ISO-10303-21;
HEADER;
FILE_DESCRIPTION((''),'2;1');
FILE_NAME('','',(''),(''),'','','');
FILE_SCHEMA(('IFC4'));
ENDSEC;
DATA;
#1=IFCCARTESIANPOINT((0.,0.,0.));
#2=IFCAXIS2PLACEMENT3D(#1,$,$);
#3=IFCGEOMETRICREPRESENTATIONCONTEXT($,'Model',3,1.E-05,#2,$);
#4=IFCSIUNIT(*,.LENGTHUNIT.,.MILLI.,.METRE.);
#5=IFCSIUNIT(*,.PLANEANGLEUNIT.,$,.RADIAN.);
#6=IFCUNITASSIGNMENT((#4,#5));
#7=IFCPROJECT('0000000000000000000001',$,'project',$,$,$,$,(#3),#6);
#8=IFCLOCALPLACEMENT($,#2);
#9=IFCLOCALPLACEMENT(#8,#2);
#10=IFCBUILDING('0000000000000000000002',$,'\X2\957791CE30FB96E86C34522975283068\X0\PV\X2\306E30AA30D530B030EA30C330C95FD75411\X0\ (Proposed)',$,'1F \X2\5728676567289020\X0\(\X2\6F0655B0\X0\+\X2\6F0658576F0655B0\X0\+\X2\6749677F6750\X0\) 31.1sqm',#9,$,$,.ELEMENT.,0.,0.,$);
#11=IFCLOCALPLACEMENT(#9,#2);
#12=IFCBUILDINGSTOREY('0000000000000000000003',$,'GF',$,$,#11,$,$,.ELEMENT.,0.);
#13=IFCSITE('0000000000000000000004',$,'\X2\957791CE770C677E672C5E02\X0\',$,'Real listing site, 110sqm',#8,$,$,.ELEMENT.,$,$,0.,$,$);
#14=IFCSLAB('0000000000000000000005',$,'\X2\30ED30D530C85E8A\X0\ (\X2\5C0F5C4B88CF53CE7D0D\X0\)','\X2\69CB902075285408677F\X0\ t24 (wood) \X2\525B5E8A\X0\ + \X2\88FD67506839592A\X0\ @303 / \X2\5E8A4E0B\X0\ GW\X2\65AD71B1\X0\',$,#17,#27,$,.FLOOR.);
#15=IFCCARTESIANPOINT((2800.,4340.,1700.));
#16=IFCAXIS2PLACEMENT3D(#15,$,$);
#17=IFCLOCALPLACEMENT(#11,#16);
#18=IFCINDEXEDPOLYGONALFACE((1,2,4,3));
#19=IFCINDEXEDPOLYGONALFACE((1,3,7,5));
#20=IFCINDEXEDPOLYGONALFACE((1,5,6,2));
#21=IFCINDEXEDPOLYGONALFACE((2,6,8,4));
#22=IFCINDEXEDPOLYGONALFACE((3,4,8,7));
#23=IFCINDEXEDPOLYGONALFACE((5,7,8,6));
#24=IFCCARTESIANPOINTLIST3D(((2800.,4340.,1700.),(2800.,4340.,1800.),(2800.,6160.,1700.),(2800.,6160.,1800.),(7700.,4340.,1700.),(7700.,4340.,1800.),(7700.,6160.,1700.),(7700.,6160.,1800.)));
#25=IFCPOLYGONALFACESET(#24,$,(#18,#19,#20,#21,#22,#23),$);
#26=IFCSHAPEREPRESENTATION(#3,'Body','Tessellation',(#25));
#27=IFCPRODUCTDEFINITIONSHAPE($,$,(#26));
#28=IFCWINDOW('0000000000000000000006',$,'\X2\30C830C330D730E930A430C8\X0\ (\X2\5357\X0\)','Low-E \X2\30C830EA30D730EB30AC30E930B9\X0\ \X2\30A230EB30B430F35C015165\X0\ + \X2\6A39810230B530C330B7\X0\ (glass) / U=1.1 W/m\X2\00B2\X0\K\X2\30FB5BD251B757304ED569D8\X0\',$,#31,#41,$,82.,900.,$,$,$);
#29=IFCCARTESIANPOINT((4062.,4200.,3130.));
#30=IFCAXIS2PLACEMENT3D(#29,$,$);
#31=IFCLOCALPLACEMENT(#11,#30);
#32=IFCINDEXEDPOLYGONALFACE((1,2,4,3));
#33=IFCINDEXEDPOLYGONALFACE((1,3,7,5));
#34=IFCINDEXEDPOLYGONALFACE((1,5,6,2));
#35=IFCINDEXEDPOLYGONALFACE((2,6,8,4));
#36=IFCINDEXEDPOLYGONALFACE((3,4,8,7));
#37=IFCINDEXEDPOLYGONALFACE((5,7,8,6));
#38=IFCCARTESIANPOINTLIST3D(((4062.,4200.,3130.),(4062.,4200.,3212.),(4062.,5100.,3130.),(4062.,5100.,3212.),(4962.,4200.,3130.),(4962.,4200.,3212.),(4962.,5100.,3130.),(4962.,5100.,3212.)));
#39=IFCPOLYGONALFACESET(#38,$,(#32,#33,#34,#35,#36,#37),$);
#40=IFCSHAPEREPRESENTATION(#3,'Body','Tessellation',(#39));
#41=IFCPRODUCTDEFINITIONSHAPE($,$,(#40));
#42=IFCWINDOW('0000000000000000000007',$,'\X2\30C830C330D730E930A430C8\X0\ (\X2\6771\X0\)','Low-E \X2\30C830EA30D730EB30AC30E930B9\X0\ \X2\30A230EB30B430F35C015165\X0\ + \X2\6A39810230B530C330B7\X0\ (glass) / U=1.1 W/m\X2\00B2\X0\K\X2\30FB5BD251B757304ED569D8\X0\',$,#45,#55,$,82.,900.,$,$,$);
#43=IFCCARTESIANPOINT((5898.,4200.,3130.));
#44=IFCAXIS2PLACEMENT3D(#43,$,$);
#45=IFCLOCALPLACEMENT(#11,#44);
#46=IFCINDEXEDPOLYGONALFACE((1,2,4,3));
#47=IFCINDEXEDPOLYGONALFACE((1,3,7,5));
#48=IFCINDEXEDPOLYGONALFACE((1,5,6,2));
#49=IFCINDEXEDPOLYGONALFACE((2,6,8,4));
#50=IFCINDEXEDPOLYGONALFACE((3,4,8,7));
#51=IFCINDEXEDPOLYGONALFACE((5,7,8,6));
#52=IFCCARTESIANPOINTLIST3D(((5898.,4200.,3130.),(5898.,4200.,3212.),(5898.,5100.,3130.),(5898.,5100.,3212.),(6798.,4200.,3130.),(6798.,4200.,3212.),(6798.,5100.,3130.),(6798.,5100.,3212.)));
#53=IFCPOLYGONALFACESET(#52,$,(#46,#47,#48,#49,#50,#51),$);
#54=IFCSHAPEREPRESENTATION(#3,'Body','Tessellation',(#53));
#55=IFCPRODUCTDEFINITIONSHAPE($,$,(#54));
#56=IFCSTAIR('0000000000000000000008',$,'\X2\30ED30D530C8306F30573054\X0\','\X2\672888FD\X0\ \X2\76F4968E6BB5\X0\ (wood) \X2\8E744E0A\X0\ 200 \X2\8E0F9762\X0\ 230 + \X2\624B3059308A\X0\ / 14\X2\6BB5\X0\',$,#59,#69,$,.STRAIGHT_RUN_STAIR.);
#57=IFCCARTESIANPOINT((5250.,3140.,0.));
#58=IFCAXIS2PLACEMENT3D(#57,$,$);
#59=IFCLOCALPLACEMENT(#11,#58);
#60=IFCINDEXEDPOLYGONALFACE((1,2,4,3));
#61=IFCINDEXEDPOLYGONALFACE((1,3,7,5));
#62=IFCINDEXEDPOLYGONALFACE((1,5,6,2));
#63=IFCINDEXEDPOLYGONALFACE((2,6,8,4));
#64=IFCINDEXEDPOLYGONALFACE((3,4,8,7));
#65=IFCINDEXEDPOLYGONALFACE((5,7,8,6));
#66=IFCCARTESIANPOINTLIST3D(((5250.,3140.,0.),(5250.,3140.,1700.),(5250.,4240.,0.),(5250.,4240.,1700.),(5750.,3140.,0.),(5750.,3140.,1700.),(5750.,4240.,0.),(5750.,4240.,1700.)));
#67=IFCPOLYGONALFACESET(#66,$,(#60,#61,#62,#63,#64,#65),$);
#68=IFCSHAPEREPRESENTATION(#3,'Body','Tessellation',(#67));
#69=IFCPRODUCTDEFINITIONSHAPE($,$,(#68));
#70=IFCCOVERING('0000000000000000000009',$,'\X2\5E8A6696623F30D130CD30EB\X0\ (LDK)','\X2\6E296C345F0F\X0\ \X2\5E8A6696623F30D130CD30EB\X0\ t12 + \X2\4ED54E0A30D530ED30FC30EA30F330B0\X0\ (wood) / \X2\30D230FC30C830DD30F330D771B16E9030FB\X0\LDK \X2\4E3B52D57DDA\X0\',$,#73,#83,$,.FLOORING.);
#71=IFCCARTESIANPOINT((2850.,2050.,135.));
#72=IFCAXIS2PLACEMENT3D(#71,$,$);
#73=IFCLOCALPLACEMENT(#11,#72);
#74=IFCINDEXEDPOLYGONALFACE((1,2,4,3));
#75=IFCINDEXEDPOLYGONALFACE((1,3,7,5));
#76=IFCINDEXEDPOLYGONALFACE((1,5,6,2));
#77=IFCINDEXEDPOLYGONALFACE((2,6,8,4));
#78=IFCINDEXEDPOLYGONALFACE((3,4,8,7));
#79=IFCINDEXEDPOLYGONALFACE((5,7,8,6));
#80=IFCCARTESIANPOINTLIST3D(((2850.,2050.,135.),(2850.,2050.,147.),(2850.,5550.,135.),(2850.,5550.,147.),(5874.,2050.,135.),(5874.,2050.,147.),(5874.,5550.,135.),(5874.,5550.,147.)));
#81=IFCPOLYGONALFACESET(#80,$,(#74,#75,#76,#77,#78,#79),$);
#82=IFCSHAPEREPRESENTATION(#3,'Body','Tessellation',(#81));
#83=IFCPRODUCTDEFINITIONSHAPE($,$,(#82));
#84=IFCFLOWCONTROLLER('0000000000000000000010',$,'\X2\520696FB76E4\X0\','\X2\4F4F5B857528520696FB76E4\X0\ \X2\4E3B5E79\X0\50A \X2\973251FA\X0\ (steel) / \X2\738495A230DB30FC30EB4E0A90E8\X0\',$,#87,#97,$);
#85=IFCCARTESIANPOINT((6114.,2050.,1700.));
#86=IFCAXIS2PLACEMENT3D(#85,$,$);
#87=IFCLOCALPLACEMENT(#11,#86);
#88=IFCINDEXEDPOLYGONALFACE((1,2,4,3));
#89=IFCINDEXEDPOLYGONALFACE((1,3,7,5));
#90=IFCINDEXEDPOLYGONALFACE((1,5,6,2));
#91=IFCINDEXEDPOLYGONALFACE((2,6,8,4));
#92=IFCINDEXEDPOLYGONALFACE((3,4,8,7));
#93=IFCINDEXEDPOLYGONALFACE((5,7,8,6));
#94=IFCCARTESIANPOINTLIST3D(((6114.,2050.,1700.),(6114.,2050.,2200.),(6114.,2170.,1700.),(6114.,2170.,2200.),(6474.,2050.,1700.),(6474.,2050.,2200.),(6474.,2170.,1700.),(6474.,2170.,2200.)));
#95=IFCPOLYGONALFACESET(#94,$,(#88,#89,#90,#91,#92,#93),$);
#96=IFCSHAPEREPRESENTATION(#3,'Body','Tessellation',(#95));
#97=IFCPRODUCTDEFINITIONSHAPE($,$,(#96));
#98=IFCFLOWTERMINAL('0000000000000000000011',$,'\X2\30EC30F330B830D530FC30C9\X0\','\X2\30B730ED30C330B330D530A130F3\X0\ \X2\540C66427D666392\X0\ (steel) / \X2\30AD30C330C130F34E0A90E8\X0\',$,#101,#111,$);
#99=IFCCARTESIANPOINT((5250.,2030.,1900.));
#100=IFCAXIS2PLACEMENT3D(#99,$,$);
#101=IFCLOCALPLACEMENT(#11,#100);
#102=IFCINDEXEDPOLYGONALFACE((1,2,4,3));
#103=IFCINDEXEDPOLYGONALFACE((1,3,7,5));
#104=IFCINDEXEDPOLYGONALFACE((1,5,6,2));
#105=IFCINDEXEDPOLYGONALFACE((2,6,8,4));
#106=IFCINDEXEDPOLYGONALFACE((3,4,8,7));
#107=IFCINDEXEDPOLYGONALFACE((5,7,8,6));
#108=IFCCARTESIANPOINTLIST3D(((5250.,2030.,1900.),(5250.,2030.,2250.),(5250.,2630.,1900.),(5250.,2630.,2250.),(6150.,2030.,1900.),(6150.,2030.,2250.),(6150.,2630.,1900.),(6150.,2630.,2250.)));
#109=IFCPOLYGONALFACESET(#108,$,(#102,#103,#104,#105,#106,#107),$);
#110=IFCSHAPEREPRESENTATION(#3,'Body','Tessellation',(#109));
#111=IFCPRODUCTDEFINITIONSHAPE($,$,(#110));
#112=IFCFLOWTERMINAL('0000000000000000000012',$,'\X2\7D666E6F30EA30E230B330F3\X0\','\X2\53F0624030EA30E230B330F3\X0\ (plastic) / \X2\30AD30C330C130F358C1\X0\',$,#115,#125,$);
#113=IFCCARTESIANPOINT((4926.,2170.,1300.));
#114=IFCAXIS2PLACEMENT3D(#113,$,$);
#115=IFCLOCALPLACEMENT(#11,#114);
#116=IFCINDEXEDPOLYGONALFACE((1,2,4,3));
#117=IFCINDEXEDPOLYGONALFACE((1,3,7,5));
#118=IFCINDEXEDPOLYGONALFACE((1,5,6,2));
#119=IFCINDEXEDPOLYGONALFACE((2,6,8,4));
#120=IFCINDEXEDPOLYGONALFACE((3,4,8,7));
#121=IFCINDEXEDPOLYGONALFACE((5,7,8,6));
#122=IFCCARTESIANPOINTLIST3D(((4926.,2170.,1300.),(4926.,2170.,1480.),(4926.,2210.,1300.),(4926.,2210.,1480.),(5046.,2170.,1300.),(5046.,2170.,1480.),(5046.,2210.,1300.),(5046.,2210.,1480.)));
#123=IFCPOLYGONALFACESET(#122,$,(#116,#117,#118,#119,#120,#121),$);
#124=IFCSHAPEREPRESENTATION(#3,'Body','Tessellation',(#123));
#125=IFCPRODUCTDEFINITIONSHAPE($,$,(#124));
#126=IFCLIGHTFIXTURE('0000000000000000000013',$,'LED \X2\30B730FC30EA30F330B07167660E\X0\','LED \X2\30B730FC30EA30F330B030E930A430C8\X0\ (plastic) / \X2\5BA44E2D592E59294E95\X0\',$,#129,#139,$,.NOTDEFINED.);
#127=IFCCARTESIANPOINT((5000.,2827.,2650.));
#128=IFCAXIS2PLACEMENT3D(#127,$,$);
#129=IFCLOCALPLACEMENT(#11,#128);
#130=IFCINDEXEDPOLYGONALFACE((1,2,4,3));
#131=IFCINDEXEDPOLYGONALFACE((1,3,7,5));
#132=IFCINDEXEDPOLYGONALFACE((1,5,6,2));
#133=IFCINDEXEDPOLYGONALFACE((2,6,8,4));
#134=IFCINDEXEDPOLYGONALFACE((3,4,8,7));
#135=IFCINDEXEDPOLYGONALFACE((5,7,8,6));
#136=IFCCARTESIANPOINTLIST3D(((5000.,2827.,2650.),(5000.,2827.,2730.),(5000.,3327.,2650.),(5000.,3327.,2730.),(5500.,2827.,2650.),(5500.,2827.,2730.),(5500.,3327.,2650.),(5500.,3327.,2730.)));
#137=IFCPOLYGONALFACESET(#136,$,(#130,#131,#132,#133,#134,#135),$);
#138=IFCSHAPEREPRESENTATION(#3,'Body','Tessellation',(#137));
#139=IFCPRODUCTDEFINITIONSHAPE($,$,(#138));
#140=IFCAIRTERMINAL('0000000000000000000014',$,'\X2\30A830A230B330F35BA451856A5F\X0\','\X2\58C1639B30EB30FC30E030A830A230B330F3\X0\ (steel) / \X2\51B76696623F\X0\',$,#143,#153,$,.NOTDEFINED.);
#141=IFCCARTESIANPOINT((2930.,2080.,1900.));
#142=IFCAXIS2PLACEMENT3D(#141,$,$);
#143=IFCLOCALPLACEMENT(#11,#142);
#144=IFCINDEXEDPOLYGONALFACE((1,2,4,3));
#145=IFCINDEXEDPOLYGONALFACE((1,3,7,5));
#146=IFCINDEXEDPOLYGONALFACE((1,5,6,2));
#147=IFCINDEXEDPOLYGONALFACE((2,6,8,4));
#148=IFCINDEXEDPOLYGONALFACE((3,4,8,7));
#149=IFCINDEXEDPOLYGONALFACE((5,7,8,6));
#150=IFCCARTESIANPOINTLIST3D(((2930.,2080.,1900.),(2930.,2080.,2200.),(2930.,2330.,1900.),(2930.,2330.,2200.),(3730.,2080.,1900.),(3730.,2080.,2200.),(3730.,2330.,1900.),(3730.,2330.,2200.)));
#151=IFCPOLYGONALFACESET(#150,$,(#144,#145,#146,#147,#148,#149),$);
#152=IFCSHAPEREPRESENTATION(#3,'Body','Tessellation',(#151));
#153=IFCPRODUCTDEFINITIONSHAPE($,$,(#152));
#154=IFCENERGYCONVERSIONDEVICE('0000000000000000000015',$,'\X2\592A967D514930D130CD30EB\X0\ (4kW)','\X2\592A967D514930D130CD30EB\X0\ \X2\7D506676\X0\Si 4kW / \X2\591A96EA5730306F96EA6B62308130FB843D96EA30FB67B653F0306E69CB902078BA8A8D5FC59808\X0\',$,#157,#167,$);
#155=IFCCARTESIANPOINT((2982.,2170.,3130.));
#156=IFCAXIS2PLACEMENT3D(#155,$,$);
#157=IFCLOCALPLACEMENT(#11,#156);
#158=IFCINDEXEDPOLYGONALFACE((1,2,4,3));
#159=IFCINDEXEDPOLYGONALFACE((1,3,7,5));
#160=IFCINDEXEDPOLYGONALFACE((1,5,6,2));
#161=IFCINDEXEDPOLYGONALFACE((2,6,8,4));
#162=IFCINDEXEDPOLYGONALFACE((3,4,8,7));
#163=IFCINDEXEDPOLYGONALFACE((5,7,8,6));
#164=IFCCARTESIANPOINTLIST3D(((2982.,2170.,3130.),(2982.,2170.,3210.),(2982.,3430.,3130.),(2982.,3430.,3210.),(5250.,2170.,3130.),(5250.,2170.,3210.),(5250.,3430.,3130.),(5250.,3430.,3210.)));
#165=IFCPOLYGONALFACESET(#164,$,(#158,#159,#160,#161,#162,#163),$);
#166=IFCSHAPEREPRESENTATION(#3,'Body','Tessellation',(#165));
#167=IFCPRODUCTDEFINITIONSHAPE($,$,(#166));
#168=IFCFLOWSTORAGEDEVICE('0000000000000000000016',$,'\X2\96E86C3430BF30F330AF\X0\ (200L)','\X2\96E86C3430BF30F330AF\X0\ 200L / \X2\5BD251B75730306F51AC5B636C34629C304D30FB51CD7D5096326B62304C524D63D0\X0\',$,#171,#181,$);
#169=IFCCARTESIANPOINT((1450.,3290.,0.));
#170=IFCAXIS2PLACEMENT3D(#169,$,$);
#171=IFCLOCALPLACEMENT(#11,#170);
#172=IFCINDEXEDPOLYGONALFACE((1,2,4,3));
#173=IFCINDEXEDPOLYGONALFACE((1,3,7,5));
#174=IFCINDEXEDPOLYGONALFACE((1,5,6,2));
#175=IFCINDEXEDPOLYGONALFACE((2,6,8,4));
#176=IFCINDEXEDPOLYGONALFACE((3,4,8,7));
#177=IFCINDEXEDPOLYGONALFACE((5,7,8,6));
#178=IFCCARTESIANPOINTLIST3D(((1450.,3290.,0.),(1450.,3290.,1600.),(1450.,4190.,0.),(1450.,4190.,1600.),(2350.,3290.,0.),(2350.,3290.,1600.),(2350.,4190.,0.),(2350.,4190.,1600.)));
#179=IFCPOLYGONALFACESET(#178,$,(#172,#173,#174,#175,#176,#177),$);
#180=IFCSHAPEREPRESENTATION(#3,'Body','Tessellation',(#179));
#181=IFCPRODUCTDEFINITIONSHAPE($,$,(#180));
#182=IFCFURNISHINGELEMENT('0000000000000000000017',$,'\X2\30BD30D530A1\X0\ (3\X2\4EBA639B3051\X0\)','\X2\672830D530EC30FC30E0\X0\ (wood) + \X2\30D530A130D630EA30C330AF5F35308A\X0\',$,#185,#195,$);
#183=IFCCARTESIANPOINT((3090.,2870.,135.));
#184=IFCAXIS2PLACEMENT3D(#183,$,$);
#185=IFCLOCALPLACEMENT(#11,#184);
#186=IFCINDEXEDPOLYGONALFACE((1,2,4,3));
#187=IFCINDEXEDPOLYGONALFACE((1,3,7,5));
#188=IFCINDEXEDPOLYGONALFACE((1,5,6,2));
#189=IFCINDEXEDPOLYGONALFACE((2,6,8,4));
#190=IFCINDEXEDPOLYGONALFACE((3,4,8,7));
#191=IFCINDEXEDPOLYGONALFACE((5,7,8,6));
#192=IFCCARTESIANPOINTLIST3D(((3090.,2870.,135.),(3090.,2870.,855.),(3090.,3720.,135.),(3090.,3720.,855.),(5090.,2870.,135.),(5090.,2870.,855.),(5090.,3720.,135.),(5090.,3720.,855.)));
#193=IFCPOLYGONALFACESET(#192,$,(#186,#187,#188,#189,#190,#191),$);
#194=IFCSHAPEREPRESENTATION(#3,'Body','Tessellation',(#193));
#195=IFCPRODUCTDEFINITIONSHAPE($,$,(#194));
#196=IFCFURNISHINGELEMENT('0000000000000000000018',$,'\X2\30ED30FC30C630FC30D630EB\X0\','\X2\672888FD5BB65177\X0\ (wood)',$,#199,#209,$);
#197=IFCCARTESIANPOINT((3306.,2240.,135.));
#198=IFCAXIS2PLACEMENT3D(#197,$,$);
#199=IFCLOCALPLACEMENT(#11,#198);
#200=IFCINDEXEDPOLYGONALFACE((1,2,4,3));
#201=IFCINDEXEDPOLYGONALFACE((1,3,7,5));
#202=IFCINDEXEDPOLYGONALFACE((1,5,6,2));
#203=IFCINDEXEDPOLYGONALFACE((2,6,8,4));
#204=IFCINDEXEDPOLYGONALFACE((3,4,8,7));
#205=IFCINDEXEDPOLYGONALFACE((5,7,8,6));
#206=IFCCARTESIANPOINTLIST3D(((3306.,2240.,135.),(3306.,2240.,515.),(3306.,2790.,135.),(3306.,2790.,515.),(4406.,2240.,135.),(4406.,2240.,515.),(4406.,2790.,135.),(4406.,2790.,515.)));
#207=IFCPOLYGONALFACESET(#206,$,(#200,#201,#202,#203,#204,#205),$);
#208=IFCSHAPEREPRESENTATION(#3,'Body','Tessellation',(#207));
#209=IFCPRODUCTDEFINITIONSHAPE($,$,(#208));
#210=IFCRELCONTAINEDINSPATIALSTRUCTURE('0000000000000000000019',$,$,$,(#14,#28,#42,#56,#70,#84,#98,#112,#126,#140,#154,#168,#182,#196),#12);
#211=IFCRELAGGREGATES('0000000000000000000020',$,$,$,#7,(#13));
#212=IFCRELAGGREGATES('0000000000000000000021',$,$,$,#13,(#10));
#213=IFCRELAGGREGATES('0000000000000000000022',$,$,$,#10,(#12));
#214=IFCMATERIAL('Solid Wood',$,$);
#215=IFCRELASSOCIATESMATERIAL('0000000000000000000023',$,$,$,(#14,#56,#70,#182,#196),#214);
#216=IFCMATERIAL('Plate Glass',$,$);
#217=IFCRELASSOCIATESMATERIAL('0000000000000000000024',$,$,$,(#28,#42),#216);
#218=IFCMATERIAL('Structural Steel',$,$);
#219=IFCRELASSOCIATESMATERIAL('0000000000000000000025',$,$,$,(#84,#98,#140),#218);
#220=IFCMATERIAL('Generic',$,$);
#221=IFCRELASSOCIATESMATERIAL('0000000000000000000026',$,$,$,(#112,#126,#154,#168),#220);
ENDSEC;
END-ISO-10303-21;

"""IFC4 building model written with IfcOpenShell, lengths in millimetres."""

from ifc_helpers import new_model, si_unit, frame, frame_2d, origin, place, context, project, spatial, rectangle, extrude, material, element, save


model = new_model("IFC4")

# Units and contexts
model_context = context("Model", 3, precision=1e-05, world=origin())
ifc_project = project(units=[si_unit("LENGTHUNIT", "METRE", prefix="MILLI"), si_unit("PLANEANGLEUNIT", "RADIAN")], contexts=[model_context])

# Site, building, storey
site_placement = place(None, origin())
site = spatial("IfcSite", under=ifc_project, at=site_placement, Name="長野県松本市", ObjectType="Real listing site, 110sqm", CompositionType="ELEMENT", RefElevation=0.0)
building_placement = place(site_placement, origin())
building = spatial("IfcBuilding", under=site, at=building_placement, Name="長野・雨水利用とPVのオフグリッド志向 (Proposed)", ObjectType="1F 在来木造(漆喰+漆塗漆喰+杉板材) 31.1sqm", CompositionType="ELEMENT", ElevationOfRefHeight=0.0, ElevationOfTerrain=0.0)
storey_placement = place(building_placement, origin())
storey = spatial("IfcBuildingStorey", under=building, at=storey_placement, Name="GF", CompositionType="ELEMENT", Elevation=0.0)

# Shared definitions
ifc_material_1 = material(Name="Solid Wood")

# Slab
slab_placement = place(storey_placement, frame((2800.0, 4340.0, 1700.0)))
element("IfcSlab", 1, at=slab_placement, inside=storey, material=ifc_material_1, Name="ロフト床 (小屋裏収納)", Description="構造用合板 t24 (wood) 剛床 + 製材根太 @303 / 床下 GW断熱", PredefinedType="FLOOR", context=model_context, shape_type="SweptSolid", body=[
    extrude(rectangle(XDim=4900.0, YDim=1820.0, at=frame_2d((2450.0, 910.0))), frame((2800.0, 4340.0, 1700.0)), (0.0, 0.0, 1.0), 100.0),
])

# Windows
ifc_material_2 = material(Name="Plate Glass")
window_1_placement = place(storey_placement, frame((4062.0, 4200.0, 3130.0)))
element("IfcWindow", 2, at=window_1_placement, inside=storey, material=ifc_material_2, Name="トップライト (南)", Description="Low-E トリプルガラス アルゴン封入 + 樹脂サッシ (glass) / U=1.1 W/m²K・寒冷地仕様", OverallHeight=82.0, OverallWidth=900.0, context=model_context, shape_type="SweptSolid", body=[
    extrude(rectangle(XDim=900.0, YDim=900.0, at=frame_2d((450.0, 450.0))), frame((4062.0, 4200.0, 3130.0)), (0.0, 0.0, 1.0), 82.0),
])
window_2_placement = place(storey_placement, frame((5898.0, 4200.0, 3130.0)))
element("IfcWindow", 3, at=window_2_placement, inside=storey, material=ifc_material_2, Name="トップライト (東)", Description="Low-E トリプルガラス アルゴン封入 + 樹脂サッシ (glass) / U=1.1 W/m²K・寒冷地仕様", OverallHeight=82.0, OverallWidth=900.0, context=model_context, shape_type="SweptSolid", body=[
    extrude(rectangle(XDim=900.0, YDim=900.0, at=frame_2d((450.0, 450.0))), frame((5898.0, 4200.0, 3130.0)), (0.0, 0.0, 1.0), 82.0),
])

# Stair
stair_placement = place(storey_placement, frame((5250.0, 3140.0, 0.0)))
element("IfcStair", 4, at=stair_placement, inside=storey, material=ifc_material_1, Name="ロフトはしご", Description="木製 直階段 (wood) 蹴上 200 踏面 230 + 手すり / 14段", PredefinedType="STRAIGHT_RUN_STAIR", context=model_context, shape_type="SweptSolid", body=[
    extrude(rectangle(XDim=500.0, YDim=1100.0, at=frame_2d((250.0, 550.0))), frame((5250.0, 3140.0, 0.0)), (0.0, 0.0, 1.0), 1700.0),
])

# Covering
covering_placement = place(storey_placement, frame((2850.0, 2050.0, 135.0)))
element("IfcCovering", 5, at=covering_placement, inside=storey, material=ifc_material_1, Name="床暖房パネル (LDK)", Description="温水式 床暖房パネル t12 + 仕上フローリング (wood) / ヒートポンプ熱源・LDK 主動線", PredefinedType="FLOORING", context=model_context, shape_type="SweptSolid", body=[
    extrude(rectangle(XDim=3024.0, YDim=3500.0, at=frame_2d((1512.0, 1750.0))), frame((2850.0, 2050.0, 135.0)), (0.0, 0.0, 1.0), 12.0),
])

# Flow controller
ifc_material_3 = material(Name="Structural Steel")
flow_controller_placement = place(storey_placement, frame((6114.0, 2050.0, 1700.0)))
element("IfcFlowController", 6, at=flow_controller_placement, inside=storey, material=ifc_material_3, Name="分電盤", Description="住宅用分電盤 主幹50A 露出 (steel) / 玄関ホール上部", context=model_context, shape_type="SweptSolid", body=[
    extrude(rectangle(XDim=360.0, YDim=120.0, at=frame_2d((180.0, 60.0))), frame((6114.0, 2050.0, 1700.0)), (0.0, 0.0, 1.0), 500.0),
])

# Flow terminals
flow_terminal_1_placement = place(storey_placement, frame((5250.0, 2030.0, 1900.0)))
element("IfcFlowTerminal", 7, at=flow_terminal_1_placement, inside=storey, material=ifc_material_3, Name="レンジフード", Description="シロッコファン 同時給排 (steel) / キッチン上部", context=model_context, shape_type="SweptSolid", body=[
    extrude(rectangle(XDim=900.0, YDim=600.0, at=frame_2d((450.0, 300.0))), frame((5250.0, 2030.0, 1900.0)), (0.0, 0.0, 1.0), 350.0),
])
ifc_material_4 = material(Name="Generic")
flow_terminal_2_placement = place(storey_placement, frame((4926.0, 2170.0, 1300.0)))
element("IfcFlowTerminal", 8, at=flow_terminal_2_placement, inside=storey, material=ifc_material_4, Name="給湯リモコン", Description="台所リモコン (plastic) / キッチン壁", context=model_context, shape_type="SweptSolid", body=[
    extrude(rectangle(XDim=120.0, YDim=40.0, at=frame_2d((60.0, 20.0))), frame((4926.0, 2170.0, 1300.0)), (0.0, 0.0, 1.0), 180.0),
])

# Light fixture
light_fixture_placement = place(storey_placement, frame((5000.0, 2827.0, 2650.0)))
element("IfcLightFixture", 9, at=light_fixture_placement, inside=storey, material=ifc_material_4, Name="LED シーリング照明", Description="LED シーリングライト (plastic) / 室中央天井", PredefinedType="NOTDEFINED", context=model_context, shape_type="SweptSolid", body=[
    extrude(rectangle(XDim=500.0, YDim=500.0, at=frame_2d((250.0, 250.0))), frame((5000.0, 2827.0, 2650.0)), (0.0, 0.0, 1.0), 80.0),
])

# Air terminal
air_terminal_placement = place(storey_placement, frame((2930.0, 2080.0, 1900.0)))
element("IfcAirTerminal", 10, at=air_terminal_placement, inside=storey, material=ifc_material_3, Name="エアコン室内機", Description="壁掛ルームエアコン (steel) / 冷暖房", PredefinedType="NOTDEFINED", context=model_context, shape_type="SweptSolid", body=[
    extrude(rectangle(XDim=800.0, YDim=250.0, at=frame_2d((400.0, 125.0))), frame((2930.0, 2080.0, 1900.0)), (0.0, 0.0, 1.0), 300.0),
])

# Energy conversion device
energy_conversion_device_placement = place(storey_placement, frame((2982.0, 2170.0, 3130.0)))
element("IfcEnergyConversionDevice", 11, at=energy_conversion_device_placement, inside=storey, material=ifc_material_4, Name="太陽光パネル (4kW)", Description="太陽光パネル 結晶Si 4kW / 多雪地は雪止め・落雪・架台の構造確認必須", context=model_context, shape_type="SweptSolid", body=[
    extrude(rectangle(XDim=2268.0, YDim=1260.0, at=frame_2d((1134.0, 630.0))), frame((2982.0, 2170.0, 3130.0)), (0.0, 0.0, 1.0), 80.0),
])

# Flow storage device
flow_storage_device_placement = place(storey_placement, frame((1450.0, 3290.0, 0.0)))
element("IfcFlowStorageDevice", 12, at=flow_storage_device_placement, inside=storey, material=ifc_material_4, Name="雨水タンク (200L)", Description="雨水タンク 200L / 寒冷地は冬季水抜き・凍結防止が前提", context=model_context, shape_type="SweptSolid", body=[
    extrude(rectangle(XDim=900.0, YDim=900.0, at=frame_2d((450.0, 450.0))), frame((1450.0, 3290.0, 0.0)), (0.0, 0.0, 1.0), 1600.0),
])

# Furnishing elements
furnishing_1_placement = place(storey_placement, frame((3090.0, 2870.0, 135.0)))
element("IfcFurnishingElement", 13, at=furnishing_1_placement, inside=storey, material=ifc_material_1, Name="ソファ (3人掛け)", Description="木フレーム (wood) + ファブリック張り", context=model_context, shape_type="SweptSolid", body=[
    extrude(rectangle(XDim=2000.0, YDim=850.0, at=frame_2d((1000.0, 425.0))), frame((3090.0, 2870.0, 135.0)), (0.0, 0.0, 1.0), 720.0),
])
furnishing_2_placement = place(storey_placement, frame((3306.0, 2240.0, 135.0)))
element("IfcFurnishingElement", 14, at=furnishing_2_placement, inside=storey, material=ifc_material_1, Name="ローテーブル", Description="木製家具 (wood)", context=model_context, shape_type="SweptSolid", body=[
    extrude(rectangle(XDim=1100.0, YDim=550.0, at=frame_2d((550.0, 275.0))), frame((3306.0, 2240.0, 135.0)), (0.0, 0.0, 1.0), 380.0),
])

save(model, "model.ifc")
